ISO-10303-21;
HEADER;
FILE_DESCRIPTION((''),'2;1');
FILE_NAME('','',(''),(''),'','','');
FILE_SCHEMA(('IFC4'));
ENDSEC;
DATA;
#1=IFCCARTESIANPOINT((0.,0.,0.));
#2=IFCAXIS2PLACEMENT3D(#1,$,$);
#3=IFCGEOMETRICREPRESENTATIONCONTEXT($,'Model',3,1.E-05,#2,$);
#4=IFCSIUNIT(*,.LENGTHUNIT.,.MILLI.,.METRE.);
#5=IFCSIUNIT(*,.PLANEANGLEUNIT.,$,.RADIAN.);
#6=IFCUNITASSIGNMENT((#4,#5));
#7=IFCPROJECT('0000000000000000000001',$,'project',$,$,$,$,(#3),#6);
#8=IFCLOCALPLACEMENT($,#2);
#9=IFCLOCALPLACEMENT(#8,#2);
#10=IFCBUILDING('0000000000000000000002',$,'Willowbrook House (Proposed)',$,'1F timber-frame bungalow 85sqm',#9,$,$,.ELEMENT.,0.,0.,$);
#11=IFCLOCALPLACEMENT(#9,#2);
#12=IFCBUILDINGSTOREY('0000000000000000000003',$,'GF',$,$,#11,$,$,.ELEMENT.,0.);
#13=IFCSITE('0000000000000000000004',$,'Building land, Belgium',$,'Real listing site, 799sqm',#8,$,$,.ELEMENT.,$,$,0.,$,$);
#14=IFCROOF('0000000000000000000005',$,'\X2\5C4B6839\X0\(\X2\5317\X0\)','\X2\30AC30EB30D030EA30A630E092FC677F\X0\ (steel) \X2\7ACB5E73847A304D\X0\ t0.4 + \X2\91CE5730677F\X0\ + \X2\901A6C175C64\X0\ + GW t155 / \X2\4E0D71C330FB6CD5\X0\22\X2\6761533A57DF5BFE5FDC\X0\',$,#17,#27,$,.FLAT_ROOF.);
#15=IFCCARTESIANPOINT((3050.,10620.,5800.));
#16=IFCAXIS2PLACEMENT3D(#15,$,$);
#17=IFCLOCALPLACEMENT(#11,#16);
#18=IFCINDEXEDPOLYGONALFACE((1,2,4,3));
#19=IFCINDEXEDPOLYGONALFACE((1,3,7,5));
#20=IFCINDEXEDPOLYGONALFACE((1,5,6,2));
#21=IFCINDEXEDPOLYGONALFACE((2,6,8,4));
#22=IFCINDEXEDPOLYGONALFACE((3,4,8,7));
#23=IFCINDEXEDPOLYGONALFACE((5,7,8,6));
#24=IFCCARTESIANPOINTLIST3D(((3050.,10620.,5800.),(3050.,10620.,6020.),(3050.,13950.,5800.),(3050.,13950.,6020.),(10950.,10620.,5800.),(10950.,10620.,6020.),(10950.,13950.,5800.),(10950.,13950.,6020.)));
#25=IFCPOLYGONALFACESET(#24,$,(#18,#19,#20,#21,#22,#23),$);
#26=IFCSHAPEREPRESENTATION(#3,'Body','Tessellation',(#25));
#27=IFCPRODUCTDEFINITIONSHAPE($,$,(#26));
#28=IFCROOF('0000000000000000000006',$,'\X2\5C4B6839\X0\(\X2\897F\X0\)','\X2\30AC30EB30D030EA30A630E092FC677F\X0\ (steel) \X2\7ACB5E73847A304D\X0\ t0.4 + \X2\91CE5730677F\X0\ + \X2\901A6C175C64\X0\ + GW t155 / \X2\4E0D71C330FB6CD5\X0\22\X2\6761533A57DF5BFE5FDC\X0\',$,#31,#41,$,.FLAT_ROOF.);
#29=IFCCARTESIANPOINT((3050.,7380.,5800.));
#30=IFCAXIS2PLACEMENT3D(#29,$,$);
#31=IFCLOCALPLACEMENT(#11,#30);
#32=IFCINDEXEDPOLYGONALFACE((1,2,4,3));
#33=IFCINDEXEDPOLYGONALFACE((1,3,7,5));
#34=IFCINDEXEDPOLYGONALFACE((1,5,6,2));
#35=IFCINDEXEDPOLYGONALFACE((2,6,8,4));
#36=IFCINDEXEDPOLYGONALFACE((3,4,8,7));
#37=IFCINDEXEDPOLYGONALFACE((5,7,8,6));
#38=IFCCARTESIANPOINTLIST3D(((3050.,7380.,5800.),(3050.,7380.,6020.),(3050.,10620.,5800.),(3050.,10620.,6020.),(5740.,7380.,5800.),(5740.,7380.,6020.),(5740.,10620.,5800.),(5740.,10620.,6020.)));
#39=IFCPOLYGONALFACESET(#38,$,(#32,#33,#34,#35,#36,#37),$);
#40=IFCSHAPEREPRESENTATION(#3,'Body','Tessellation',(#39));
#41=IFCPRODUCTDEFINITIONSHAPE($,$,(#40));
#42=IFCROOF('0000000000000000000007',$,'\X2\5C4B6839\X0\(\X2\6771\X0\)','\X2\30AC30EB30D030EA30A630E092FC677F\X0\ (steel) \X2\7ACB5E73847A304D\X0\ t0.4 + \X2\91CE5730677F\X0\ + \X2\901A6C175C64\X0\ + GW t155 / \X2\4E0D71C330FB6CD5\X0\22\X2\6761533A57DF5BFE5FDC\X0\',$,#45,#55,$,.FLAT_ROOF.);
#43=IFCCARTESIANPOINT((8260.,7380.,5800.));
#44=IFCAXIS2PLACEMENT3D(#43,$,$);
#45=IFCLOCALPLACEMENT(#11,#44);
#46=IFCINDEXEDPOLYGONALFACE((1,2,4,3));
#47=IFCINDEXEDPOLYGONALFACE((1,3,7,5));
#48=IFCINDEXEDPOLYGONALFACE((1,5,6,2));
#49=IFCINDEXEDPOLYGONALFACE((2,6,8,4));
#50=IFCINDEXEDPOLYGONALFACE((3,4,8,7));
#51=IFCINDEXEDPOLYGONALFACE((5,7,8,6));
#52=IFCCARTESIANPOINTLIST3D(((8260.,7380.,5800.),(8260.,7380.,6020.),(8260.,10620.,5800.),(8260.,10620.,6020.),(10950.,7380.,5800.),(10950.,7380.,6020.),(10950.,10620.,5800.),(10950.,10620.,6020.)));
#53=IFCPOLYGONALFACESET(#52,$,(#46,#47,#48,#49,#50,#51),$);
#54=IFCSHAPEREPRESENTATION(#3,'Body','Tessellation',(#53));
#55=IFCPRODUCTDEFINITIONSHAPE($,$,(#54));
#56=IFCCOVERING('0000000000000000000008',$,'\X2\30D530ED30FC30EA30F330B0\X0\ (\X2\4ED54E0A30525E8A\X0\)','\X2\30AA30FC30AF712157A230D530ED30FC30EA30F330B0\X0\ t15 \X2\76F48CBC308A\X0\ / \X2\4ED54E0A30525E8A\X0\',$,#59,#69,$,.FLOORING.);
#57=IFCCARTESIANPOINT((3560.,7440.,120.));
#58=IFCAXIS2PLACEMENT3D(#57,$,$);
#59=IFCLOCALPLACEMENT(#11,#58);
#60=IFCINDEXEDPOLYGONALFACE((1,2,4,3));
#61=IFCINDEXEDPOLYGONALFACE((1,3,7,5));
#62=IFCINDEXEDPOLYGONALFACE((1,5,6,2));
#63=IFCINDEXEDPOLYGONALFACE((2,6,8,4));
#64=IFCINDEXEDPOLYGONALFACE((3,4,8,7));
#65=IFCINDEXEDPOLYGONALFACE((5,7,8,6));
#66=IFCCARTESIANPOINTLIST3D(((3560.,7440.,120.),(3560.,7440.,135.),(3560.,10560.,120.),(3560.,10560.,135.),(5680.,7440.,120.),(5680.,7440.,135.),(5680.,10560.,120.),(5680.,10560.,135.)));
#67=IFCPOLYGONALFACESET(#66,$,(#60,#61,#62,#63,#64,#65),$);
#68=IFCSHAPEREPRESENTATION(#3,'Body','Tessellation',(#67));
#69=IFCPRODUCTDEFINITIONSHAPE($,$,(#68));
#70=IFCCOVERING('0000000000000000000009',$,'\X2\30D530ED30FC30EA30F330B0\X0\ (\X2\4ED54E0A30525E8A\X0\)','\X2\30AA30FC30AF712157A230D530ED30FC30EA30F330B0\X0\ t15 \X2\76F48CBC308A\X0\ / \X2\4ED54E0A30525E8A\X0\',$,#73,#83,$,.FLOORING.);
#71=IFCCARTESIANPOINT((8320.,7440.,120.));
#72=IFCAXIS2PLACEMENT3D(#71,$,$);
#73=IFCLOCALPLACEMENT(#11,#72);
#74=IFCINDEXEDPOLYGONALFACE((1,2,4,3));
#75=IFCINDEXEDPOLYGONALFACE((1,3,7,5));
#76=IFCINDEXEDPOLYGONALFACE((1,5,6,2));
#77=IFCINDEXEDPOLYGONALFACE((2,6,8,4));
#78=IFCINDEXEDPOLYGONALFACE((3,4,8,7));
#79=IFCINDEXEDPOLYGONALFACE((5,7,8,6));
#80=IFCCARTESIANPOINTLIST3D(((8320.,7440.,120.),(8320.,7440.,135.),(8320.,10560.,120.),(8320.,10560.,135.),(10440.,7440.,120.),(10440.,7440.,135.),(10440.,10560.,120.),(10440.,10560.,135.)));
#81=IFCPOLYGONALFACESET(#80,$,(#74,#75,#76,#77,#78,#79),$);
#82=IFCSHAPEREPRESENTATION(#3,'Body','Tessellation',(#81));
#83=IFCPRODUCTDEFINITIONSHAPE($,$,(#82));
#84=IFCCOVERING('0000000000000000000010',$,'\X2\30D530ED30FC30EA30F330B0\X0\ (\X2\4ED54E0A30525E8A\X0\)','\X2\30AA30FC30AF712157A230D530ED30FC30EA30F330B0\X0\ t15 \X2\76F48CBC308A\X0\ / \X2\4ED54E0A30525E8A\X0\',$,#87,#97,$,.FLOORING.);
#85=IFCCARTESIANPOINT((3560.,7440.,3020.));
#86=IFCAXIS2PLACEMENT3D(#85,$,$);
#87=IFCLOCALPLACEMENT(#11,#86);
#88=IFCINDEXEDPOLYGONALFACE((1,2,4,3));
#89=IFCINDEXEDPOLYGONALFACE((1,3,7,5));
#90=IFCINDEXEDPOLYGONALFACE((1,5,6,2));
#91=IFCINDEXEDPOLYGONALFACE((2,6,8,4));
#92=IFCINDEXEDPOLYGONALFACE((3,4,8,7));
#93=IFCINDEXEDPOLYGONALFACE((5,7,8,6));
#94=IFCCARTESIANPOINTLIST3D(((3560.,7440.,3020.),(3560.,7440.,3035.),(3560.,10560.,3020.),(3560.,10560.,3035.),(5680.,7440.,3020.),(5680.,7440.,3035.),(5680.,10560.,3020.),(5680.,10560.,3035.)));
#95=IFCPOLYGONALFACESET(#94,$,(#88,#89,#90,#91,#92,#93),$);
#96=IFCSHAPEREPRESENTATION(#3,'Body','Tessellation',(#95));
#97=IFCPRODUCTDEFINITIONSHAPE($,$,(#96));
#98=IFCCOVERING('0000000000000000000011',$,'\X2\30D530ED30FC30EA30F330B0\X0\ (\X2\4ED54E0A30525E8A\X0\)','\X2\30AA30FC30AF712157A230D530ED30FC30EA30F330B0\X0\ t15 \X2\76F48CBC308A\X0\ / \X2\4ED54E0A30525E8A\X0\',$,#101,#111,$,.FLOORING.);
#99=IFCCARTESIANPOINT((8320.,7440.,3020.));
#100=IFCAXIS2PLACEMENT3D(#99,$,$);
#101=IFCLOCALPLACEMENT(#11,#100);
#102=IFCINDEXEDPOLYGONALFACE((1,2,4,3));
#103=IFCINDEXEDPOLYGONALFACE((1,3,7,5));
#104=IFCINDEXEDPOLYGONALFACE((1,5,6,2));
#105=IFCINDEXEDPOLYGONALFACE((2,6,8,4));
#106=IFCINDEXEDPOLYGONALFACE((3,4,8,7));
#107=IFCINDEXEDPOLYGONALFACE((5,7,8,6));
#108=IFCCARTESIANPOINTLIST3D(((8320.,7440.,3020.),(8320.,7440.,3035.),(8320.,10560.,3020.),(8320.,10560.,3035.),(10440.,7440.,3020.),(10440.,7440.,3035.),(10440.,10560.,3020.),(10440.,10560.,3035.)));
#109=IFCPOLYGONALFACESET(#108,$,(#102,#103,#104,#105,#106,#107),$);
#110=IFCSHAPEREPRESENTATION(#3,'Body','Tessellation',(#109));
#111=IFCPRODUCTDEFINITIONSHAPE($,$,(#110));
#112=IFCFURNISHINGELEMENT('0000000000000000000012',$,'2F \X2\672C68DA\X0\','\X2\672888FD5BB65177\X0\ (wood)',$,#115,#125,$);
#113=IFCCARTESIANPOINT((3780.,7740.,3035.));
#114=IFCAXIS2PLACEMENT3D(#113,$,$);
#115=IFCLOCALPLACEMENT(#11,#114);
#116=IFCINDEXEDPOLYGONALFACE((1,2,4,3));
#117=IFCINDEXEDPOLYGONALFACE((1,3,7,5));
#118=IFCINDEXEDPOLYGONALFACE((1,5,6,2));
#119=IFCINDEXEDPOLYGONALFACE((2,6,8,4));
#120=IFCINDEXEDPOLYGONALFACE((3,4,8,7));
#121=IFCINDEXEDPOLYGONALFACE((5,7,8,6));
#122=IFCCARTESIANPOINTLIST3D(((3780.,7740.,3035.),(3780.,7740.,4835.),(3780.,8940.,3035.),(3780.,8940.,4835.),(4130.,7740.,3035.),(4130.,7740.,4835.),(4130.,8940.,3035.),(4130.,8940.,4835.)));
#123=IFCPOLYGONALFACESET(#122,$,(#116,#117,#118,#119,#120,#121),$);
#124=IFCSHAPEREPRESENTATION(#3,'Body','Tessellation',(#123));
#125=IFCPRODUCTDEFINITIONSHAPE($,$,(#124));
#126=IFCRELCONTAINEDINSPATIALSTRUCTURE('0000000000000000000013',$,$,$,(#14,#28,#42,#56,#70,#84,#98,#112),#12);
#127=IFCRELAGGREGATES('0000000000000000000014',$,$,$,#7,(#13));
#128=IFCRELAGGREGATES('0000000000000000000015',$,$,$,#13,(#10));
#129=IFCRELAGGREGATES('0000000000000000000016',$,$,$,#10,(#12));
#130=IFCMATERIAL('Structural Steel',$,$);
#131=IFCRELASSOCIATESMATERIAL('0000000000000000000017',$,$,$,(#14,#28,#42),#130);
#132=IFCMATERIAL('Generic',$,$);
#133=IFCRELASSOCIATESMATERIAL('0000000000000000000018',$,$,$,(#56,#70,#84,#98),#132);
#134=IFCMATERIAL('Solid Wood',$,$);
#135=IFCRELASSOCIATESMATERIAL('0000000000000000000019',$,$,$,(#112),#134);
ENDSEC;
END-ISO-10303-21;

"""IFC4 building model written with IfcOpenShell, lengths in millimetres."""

from ifc_helpers import new_model, si_unit, frame, frame_2d, origin, place, context, project, spatial, rectangle, extrude, material, element, save


model = new_model("IFC4")

# Units and contexts
model_context = context("Model", 3, precision=1e-05, world=origin())
ifc_project = project(units=[si_unit("LENGTHUNIT", "METRE", prefix="MILLI"), si_unit("PLANEANGLEUNIT", "RADIAN")], contexts=[model_context])

# Site, building, storey
site_placement = place(None, origin())
site = spatial("IfcSite", under=ifc_project, at=site_placement, Name="Building land, Belgium", ObjectType="Real listing site, 799sqm", CompositionType="ELEMENT", RefElevation=0.0)
building_placement = place(site_placement, origin())
building = spatial("IfcBuilding", under=site, at=building_placement, Name="Willowbrook House (Proposed)", ObjectType="1F timber-frame bungalow 85sqm", CompositionType="ELEMENT", ElevationOfRefHeight=0.0, ElevationOfTerrain=0.0)
storey_placement = place(building_placement, origin())
storey = spatial("IfcBuildingStorey", under=building, at=storey_placement, Name="GF", CompositionType="ELEMENT", Elevation=0.0)

# Shared definitions
ifc_material_1 = material(Name="Solid Wood")

# Shared definitions
ifc_material_2 = material(Name="Generic")

# Roofs
ifc_material_3 = material(Name="Structural Steel")
roof_1_placement = place(storey_placement, frame((3050.0, 10620.0, 5800.0)))
element("IfcRoof", 1, at=roof_1_placement, inside=storey, material=ifc_material_3, Name="屋根(北)", Description="ガルバリウム鋼板 (steel) 立平葺き t0.4 + 野地板 + 通気層 + GW t155 / 不燃・法22条区域対応", PredefinedType="FLAT_ROOF", context=model_context, shape_type="SweptSolid", body=[
    extrude(rectangle(XDim=7900.0, YDim=3330.0, at=frame_2d((3950.0, 1665.0))), frame((3050.0, 10620.0, 5800.0)), (0.0, 0.0, 1.0), 220.0),
])
roof_2_placement = place(storey_placement, frame((3050.0, 7380.0, 5800.0)))
element("IfcRoof", 2, at=roof_2_placement, inside=storey, material=ifc_material_3, Name="屋根(西)", Description="ガルバリウム鋼板 (steel) 立平葺き t0.4 + 野地板 + 通気層 + GW t155 / 不燃・法22条区域対応", PredefinedType="FLAT_ROOF", context=model_context, shape_type="SweptSolid", body=[
    extrude(rectangle(XDim=2690.0, YDim=3240.0, at=frame_2d((1345.0, 1620.0))), frame((3050.0, 7380.0, 5800.0)), (0.0, 0.0, 1.0), 220.0),
])
roof_3_placement = place(storey_placement, frame((8260.0, 7380.0, 5800.0)))
element("IfcRoof", 3, at=roof_3_placement, inside=storey, material=ifc_material_3, Name="屋根(東)", Description="ガルバリウム鋼板 (steel) 立平葺き t0.4 + 野地板 + 通気層 + GW t155 / 不燃・法22条区域対応", PredefinedType="FLAT_ROOF", context=model_context, shape_type="SweptSolid", body=[
    extrude(rectangle(XDim=2690.0, YDim=3240.0, at=frame_2d((1345.0, 1620.0))), frame((8260.0, 7380.0, 5800.0)), (0.0, 0.0, 1.0), 220.0),
])

# Coverings
covering_1_placement = place(storey_placement, frame((3560.0, 7440.0, 120.0)))
element("IfcCovering", 4, at=covering_1_placement, inside=storey, material=ifc_material_2, Name="フローリング (仕上げ床)", Description="オーク無垢フローリング t15 直貼り / 仕上げ床", PredefinedType="FLOORING", context=model_context, shape_type="SweptSolid", body=[
    extrude(rectangle(XDim=2120.0, YDim=3120.0, at=frame_2d((1060.0, 1560.0))), frame((3560.0, 7440.0, 120.0)), (0.0, 0.0, 1.0), 15.0),
])
covering_2_placement = place(storey_placement, frame((8320.0, 7440.0, 120.0)))
element("IfcCovering", 5, at=covering_2_placement, inside=storey, material=ifc_material_2, Name="フローリング (仕上げ床)", Description="オーク無垢フローリング t15 直貼り / 仕上げ床", PredefinedType="FLOORING", context=model_context, shape_type="SweptSolid", body=[
    extrude(rectangle(XDim=2120.0, YDim=3120.0, at=frame_2d((1060.0, 1560.0))), frame((8320.0, 7440.0, 120.0)), (0.0, 0.0, 1.0), 15.0),
])
covering_3_placement = place(storey_placement, frame((3560.0, 7440.0, 3020.0)))
element("IfcCovering", 6, at=covering_3_placement, inside=storey, material=ifc_material_2, Name="フローリング (仕上げ床)", Description="オーク無垢フローリング t15 直貼り / 仕上げ床", PredefinedType="FLOORING", context=model_context, shape_type="SweptSolid", body=[
    extrude(rectangle(XDim=2120.0, YDim=3120.0, at=frame_2d((1060.0, 1560.0))), frame((3560.0, 7440.0, 3020.0)), (0.0, 0.0, 1.0), 15.0),
])
covering_4_placement = place(storey_placement, frame((8320.0, 7440.0, 3020.0)))
element("IfcCovering", 7, at=covering_4_placement, inside=storey, material=ifc_material_2, Name="フローリング (仕上げ床)", Description="オーク無垢フローリング t15 直貼り / 仕上げ床", PredefinedType="FLOORING", context=model_context, shape_type="SweptSolid", body=[
    extrude(rectangle(XDim=2120.0, YDim=3120.0, at=frame_2d((1060.0, 1560.0))), frame((8320.0, 7440.0, 3020.0)), (0.0, 0.0, 1.0), 15.0),
])

# Furnishing element
furnishing_placement = place(storey_placement, frame((3780.0, 7740.0, 3035.0)))
element("IfcFurnishingElement", 8, at=furnishing_placement, inside=storey, material=ifc_material_1, Name="2F 本棚", Description="木製家具 (wood)", context=model_context, shape_type="SweptSolid", body=[
    extrude(rectangle(XDim=350.0, YDim=1200.0, at=frame_2d((175.0, 600.0))), frame((3780.0, 7740.0, 3035.0)), (0.0, 0.0, 1.0), 1800.0),
])

save(model, "model.ifc")
